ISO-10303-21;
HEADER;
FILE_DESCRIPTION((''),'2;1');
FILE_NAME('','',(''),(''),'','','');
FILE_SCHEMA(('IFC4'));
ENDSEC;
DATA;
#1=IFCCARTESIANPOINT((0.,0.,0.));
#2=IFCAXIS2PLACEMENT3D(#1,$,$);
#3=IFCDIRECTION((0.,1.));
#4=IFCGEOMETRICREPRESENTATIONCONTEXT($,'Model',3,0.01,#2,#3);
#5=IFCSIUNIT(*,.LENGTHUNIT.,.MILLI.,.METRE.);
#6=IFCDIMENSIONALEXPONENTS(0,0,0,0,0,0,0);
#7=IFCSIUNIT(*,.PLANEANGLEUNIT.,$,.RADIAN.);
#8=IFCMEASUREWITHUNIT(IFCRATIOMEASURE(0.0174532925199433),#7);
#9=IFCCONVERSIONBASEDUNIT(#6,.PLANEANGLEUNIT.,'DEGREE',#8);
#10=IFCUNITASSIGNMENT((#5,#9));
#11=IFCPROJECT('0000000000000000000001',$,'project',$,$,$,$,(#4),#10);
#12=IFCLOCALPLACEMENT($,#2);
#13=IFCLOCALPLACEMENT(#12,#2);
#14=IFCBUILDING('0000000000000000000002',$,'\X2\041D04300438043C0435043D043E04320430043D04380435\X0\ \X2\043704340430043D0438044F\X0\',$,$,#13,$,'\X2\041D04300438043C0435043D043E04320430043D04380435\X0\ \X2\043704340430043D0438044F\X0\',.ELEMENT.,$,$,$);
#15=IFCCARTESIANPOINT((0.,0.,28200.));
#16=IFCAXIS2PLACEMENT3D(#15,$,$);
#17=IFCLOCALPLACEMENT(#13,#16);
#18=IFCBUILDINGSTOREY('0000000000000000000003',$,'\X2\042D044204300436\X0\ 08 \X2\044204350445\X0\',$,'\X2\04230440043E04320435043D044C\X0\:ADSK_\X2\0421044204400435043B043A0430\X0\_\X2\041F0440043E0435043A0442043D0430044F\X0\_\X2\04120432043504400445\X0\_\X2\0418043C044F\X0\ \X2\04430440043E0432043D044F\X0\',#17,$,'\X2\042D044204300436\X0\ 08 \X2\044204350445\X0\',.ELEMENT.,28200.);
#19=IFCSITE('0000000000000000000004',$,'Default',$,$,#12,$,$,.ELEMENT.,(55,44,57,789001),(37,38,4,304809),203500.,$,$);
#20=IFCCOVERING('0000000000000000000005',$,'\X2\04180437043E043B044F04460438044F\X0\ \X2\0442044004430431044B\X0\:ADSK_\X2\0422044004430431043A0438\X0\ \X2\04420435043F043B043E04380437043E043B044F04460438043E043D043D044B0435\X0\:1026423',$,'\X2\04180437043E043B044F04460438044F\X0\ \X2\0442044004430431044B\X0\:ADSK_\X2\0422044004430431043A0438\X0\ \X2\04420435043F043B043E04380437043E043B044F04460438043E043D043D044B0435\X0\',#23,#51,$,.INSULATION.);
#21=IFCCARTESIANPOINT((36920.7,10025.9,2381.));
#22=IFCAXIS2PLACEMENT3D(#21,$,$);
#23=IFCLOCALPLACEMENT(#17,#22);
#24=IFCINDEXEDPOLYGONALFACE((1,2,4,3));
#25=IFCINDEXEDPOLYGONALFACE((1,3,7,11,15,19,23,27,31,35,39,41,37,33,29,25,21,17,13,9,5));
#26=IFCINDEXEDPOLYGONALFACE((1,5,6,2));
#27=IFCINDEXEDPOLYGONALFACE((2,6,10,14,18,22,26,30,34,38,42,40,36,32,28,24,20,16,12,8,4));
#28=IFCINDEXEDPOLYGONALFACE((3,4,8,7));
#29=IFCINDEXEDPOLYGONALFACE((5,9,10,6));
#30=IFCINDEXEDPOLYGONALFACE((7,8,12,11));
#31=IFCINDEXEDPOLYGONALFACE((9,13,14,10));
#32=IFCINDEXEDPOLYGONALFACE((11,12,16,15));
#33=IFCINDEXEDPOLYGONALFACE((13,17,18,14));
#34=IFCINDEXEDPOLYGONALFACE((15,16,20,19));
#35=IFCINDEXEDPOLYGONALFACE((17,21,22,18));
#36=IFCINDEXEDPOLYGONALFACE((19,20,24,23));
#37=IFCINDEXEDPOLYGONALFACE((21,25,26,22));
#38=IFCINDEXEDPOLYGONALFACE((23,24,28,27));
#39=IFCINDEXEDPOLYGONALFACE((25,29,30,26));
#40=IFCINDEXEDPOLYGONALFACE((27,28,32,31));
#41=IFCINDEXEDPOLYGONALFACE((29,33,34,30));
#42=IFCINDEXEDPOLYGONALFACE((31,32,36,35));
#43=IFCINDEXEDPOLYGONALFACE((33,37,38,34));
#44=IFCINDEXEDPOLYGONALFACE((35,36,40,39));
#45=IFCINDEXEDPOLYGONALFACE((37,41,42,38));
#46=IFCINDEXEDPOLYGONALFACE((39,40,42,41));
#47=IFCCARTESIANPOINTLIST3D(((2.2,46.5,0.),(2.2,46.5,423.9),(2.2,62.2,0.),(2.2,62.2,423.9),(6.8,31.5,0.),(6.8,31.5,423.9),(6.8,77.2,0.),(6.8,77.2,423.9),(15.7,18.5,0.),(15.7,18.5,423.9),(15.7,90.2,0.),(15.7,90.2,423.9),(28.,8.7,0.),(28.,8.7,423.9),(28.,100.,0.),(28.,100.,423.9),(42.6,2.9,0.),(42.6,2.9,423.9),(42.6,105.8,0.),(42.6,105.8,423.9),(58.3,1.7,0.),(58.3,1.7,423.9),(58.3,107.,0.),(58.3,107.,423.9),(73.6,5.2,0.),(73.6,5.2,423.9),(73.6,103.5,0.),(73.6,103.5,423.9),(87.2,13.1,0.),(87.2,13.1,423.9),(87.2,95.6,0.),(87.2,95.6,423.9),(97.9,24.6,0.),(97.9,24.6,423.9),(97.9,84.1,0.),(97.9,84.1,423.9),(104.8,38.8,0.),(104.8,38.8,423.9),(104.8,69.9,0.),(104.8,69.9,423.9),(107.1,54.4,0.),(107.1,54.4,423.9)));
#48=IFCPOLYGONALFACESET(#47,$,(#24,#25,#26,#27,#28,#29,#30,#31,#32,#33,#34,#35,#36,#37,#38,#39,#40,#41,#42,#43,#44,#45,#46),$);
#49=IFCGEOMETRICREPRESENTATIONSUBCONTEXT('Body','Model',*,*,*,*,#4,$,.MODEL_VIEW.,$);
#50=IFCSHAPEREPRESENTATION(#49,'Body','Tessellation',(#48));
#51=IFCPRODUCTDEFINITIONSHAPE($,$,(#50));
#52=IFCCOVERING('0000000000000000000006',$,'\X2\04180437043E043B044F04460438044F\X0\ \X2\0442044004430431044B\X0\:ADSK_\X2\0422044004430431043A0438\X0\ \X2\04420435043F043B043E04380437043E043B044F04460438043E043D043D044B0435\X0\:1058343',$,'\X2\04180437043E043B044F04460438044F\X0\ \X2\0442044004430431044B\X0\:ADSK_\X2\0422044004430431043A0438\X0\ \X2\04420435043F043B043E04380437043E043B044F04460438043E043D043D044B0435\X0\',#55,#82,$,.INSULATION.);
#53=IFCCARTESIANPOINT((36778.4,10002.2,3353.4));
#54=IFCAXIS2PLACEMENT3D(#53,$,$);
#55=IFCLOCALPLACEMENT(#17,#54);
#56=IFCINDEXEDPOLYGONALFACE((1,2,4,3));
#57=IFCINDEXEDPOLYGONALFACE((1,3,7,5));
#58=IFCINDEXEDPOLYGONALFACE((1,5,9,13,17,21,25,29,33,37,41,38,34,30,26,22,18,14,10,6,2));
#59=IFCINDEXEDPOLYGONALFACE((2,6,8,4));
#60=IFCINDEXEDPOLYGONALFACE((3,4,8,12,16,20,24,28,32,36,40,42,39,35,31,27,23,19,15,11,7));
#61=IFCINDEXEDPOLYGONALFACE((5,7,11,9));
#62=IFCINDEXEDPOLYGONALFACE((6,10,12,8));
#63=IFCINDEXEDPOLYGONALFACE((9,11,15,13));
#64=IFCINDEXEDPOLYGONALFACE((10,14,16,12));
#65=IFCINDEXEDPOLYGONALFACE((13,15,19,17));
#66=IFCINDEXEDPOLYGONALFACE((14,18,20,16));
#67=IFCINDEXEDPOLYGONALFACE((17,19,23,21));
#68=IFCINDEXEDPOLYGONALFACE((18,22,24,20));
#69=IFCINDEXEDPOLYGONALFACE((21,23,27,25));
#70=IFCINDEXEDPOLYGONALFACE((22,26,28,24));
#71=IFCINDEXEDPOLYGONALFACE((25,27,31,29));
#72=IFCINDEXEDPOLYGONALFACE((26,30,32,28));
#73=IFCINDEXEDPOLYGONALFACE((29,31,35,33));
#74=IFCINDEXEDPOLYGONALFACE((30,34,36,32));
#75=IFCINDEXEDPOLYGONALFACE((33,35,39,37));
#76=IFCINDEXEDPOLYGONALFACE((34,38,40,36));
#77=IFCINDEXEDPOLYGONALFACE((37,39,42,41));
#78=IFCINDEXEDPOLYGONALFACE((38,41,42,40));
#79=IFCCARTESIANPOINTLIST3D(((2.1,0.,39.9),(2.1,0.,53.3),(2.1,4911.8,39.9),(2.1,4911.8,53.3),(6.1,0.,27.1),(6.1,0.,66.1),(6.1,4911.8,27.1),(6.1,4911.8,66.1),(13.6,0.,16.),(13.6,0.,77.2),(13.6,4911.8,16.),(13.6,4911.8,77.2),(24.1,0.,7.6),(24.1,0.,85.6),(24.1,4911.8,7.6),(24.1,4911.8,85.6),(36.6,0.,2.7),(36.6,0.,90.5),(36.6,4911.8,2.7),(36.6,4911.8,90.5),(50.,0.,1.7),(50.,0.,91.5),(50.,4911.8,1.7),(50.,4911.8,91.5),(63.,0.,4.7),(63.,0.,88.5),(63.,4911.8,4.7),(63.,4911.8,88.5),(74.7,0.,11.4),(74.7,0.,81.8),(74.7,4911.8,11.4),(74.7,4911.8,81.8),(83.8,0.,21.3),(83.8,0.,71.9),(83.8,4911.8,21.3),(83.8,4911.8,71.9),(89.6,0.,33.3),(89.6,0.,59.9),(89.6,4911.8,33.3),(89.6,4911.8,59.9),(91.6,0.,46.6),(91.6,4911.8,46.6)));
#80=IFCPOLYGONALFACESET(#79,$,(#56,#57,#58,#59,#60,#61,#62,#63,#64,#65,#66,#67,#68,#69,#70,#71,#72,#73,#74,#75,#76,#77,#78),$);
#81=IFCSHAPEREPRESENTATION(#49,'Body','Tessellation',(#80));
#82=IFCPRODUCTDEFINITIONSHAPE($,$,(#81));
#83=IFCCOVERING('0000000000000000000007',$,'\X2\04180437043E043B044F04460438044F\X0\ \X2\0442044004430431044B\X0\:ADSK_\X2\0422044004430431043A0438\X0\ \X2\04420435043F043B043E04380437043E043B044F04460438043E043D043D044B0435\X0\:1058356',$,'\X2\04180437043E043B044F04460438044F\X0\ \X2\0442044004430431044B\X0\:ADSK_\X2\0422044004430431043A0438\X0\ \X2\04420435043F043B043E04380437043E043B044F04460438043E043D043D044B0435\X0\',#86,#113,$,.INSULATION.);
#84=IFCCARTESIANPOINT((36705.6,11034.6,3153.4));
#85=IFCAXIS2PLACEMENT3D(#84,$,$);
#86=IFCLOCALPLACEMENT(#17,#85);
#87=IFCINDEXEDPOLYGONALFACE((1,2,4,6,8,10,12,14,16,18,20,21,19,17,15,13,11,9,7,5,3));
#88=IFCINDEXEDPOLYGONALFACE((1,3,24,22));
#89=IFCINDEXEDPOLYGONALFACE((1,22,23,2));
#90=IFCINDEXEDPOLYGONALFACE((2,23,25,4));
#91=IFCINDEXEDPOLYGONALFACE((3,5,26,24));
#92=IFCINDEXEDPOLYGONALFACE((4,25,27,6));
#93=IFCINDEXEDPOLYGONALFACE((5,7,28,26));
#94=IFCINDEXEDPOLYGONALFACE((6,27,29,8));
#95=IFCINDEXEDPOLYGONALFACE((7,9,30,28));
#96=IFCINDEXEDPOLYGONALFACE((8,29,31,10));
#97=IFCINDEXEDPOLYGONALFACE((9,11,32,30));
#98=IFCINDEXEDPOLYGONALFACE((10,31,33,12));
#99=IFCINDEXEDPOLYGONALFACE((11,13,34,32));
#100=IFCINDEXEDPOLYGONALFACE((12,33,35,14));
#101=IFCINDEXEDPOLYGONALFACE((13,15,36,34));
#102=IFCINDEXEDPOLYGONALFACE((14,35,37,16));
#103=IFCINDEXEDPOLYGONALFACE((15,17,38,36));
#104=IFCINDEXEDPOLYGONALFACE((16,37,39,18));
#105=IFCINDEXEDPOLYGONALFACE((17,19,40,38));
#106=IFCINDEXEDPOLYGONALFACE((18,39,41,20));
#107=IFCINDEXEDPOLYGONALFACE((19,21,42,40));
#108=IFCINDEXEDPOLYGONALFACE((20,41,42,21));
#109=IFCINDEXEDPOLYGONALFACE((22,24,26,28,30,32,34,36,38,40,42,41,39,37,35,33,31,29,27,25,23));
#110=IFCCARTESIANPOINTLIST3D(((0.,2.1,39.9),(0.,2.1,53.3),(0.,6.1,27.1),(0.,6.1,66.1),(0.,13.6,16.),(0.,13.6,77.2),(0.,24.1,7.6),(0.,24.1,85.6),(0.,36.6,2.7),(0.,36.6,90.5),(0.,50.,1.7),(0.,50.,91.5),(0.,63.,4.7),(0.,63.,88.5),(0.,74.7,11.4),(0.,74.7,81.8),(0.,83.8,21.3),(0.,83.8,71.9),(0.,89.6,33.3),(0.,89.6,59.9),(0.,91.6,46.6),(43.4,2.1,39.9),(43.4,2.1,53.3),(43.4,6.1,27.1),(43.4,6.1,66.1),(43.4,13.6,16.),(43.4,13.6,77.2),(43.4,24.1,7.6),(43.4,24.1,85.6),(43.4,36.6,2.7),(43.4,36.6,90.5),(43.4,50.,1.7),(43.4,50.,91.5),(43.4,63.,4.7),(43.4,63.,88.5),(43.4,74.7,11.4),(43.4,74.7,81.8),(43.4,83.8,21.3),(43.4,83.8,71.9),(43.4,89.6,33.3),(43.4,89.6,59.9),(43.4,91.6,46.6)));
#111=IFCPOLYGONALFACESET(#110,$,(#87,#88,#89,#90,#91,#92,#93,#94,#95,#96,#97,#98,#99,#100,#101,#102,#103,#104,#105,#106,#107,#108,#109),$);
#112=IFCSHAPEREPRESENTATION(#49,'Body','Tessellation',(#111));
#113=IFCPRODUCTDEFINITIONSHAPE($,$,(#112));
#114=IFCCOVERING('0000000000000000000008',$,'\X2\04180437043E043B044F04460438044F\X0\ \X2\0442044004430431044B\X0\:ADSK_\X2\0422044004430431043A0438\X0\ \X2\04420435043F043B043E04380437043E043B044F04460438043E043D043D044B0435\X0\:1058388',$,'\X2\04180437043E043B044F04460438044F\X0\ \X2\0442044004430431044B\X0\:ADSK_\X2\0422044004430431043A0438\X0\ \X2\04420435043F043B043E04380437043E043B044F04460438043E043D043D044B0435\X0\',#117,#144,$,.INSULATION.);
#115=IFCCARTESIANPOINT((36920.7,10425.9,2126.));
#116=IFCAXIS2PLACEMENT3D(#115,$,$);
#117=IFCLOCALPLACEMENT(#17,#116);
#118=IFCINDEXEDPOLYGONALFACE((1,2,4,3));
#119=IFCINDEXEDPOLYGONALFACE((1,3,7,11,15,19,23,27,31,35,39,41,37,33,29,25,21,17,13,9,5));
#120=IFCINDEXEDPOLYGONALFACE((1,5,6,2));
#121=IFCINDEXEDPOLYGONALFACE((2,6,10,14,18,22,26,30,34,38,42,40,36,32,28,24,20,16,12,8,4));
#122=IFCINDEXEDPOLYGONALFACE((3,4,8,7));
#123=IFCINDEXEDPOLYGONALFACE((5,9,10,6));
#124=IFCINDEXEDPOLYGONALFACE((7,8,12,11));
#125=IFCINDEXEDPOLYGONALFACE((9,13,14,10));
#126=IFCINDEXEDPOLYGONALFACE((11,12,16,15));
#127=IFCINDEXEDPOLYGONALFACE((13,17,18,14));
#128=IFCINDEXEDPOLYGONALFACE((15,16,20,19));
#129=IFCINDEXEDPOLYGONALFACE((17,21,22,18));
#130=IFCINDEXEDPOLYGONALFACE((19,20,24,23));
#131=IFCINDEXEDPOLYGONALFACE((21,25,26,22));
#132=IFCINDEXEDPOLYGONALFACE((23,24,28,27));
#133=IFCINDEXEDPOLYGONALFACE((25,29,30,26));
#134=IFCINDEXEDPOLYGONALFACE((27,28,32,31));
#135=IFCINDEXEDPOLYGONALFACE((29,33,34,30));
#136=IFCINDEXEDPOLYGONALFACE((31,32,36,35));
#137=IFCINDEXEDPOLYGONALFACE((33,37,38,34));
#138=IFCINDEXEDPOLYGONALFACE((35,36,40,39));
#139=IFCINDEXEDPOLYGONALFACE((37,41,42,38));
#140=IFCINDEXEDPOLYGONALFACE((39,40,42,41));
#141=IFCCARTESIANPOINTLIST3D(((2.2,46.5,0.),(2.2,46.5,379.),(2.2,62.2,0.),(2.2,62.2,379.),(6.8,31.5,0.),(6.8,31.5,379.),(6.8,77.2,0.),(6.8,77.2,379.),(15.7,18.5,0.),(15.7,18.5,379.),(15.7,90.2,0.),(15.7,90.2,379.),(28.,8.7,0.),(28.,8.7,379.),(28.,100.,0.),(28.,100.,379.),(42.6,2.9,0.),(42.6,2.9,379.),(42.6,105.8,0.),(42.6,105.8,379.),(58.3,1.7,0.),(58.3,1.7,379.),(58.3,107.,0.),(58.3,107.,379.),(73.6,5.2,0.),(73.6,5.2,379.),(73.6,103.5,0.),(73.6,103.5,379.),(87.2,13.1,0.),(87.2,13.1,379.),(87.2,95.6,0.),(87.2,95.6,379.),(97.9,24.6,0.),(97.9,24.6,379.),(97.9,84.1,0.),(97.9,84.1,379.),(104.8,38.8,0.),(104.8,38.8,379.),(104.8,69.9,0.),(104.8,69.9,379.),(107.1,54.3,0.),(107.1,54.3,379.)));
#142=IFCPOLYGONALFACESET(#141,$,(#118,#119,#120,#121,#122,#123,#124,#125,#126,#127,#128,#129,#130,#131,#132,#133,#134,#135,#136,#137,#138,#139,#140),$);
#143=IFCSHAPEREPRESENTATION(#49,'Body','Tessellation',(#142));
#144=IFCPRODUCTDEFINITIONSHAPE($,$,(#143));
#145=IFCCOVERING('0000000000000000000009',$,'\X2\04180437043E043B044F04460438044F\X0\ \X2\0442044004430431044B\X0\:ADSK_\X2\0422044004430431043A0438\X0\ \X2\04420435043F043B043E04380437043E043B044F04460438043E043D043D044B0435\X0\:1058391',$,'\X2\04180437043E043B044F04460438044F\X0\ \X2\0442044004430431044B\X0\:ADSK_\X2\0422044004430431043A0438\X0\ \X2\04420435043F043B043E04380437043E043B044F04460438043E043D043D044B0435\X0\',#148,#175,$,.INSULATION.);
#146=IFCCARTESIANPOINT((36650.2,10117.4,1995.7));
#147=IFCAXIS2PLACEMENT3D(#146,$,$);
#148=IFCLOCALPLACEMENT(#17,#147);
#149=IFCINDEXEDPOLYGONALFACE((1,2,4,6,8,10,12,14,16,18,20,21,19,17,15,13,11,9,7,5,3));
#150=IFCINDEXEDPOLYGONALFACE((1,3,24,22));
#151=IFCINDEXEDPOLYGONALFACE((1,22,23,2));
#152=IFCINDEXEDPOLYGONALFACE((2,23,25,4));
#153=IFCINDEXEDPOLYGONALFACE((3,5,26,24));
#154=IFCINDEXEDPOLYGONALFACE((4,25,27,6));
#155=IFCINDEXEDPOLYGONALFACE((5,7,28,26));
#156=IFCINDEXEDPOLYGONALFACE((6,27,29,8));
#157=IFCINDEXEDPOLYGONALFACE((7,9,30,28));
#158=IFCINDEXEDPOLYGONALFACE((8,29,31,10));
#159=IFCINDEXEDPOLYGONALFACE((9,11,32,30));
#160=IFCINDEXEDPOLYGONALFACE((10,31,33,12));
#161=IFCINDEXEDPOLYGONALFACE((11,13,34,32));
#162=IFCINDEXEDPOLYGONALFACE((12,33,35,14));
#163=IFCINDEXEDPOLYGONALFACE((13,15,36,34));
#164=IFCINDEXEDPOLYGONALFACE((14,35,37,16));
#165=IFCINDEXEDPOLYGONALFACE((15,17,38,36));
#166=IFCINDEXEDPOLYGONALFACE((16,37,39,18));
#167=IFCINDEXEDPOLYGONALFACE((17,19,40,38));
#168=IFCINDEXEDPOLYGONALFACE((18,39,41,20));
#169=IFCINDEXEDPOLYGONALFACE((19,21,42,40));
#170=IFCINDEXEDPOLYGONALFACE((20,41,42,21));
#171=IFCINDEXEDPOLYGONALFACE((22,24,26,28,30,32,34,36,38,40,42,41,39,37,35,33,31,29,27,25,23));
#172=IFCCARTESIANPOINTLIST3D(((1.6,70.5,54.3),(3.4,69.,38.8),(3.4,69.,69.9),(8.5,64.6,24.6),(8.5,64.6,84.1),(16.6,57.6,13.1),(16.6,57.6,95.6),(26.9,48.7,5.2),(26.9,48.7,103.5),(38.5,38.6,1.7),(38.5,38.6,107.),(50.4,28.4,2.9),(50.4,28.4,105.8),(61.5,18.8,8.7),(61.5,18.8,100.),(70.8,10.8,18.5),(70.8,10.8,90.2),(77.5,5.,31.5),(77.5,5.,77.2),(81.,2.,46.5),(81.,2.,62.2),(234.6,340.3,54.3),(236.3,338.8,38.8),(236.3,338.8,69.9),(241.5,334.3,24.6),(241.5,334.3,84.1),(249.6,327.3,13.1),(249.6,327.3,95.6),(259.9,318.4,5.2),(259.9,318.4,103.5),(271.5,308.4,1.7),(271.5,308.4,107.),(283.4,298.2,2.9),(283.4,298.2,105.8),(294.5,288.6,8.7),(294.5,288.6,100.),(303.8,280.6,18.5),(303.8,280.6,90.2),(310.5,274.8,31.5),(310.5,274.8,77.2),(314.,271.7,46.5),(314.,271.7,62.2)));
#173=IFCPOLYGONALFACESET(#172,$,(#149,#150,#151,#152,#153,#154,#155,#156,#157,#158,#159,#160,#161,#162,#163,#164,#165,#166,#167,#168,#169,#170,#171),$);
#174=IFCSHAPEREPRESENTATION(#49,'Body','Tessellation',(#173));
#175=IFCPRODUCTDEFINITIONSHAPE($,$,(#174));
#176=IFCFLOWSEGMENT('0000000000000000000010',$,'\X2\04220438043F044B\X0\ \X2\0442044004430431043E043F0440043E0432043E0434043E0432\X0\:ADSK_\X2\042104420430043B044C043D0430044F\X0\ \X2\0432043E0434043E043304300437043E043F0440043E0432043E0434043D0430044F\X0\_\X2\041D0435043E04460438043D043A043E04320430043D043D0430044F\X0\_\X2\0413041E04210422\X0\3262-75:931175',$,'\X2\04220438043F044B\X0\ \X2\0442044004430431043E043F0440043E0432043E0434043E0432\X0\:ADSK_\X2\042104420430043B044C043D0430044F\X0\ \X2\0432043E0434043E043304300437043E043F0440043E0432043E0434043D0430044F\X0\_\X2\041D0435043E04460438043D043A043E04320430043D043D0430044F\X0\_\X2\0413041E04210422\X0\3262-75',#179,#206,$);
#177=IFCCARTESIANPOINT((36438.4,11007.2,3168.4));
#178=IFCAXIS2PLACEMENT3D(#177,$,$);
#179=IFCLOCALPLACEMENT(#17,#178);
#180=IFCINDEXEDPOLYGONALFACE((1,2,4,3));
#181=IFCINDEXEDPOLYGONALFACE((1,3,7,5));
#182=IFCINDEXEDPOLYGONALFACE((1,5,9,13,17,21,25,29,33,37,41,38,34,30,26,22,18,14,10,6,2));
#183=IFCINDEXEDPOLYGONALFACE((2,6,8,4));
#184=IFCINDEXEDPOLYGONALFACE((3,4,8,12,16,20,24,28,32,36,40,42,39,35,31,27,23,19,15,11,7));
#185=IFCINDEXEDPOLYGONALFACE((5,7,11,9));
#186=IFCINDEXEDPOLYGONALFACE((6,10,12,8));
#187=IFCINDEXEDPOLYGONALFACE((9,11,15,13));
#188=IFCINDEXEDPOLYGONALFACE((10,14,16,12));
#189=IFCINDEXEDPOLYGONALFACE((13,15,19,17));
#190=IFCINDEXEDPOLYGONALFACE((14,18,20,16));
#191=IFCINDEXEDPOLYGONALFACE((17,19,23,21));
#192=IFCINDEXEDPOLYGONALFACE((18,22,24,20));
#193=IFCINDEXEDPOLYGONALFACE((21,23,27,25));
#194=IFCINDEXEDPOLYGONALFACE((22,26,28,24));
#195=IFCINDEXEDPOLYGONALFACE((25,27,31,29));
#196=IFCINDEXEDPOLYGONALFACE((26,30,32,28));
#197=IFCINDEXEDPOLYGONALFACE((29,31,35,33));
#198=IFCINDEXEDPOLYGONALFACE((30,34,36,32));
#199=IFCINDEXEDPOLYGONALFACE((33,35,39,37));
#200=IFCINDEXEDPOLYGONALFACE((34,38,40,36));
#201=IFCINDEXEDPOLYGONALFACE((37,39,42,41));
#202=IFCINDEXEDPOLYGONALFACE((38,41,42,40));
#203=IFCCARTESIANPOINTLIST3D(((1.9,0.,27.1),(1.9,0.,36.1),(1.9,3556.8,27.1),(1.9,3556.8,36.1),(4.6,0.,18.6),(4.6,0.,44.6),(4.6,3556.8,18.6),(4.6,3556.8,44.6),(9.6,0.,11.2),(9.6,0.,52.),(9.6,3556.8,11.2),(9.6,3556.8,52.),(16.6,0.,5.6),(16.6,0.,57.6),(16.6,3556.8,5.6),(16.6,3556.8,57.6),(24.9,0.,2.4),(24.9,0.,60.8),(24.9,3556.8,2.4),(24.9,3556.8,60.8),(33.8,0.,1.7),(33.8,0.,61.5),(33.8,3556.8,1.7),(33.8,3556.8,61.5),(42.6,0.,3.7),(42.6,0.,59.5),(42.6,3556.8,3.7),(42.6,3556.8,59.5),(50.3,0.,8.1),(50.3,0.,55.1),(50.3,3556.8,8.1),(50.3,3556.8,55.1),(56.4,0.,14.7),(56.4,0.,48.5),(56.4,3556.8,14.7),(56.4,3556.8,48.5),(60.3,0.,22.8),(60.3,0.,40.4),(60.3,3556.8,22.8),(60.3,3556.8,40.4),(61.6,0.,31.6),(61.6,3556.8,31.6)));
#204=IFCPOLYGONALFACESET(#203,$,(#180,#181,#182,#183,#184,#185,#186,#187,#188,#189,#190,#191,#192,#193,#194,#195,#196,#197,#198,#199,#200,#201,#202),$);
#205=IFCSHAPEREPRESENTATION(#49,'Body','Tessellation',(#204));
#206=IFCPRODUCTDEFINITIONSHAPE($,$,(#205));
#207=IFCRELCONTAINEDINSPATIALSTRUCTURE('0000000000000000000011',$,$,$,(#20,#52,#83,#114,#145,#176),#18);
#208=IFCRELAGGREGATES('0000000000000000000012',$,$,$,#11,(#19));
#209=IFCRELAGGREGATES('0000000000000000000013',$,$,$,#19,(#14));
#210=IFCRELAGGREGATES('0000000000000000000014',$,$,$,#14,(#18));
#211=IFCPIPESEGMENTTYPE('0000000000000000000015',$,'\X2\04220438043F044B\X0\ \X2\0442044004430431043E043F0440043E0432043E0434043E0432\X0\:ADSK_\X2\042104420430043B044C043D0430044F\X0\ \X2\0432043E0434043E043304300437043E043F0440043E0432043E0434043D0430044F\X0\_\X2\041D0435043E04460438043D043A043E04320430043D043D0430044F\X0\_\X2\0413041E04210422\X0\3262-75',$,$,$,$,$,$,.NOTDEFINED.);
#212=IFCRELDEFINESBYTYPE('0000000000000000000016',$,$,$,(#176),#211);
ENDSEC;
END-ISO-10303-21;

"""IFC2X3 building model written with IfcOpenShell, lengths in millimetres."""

from ifc_helpers import new_model, entity, si_unit, converted_unit, direction, frame, origin, origin_2d_with_axis, place, context, subcontext, project, spatial, circle, extrude, type_object, element, save


model = new_model("IFC2X3")

# Units and contexts
model_context = context("Model", 3, precision=0.01, world=origin(), true_north=direction((0.0, 1.0)))
body_context = subcontext(model_context, "Body", "Model", "MODEL_VIEW")
ifc_project = project(units=[si_unit("LENGTHUNIT", "METRE", prefix="MILLI"), converted_unit("PLANEANGLEUNIT", "DEGREE", entity("IfcRatioMeasure", 0.0174532925199433), si_unit("PLANEANGLEUNIT", "RADIAN"), dimensions=[0, 0, 0, 0, 0, 0, 0])], contexts=[model_context])

# Site, building, storey
site_placement = place(None, origin())
site = spatial("IfcSite", under=ifc_project, at=site_placement, Name="Default", CompositionType="ELEMENT", RefLatitude=(55, 44, 57, 789001), RefLongitude=(37, 38, 4, 304809), RefElevation=203500.0)
building_placement = place(site_placement, origin())
building = spatial("IfcBuilding", under=site, at=building_placement, Name="Наименование здания", LongName="Наименование здания", CompositionType="ELEMENT")
storey_placement = place(building_placement, frame((0.0, 0.0, 28200.0)))
storey = spatial("IfcBuildingStorey", under=building, at=storey_placement, Name="Этаж 08 тех", ObjectType="Уровень:ADSK_Стрелка_Проектная_Вверх_Имя уровня", LongName="Этаж 08 тех", CompositionType="ELEMENT", Elevation=28200.0)

# Coverings
covering_1_placement = place(storey_placement, frame((36920.7, 10025.9, 2381.0)))
element("IfcCovering", 1, at=covering_1_placement, inside=storey, Name="Изоляция трубы:ADSK_Трубки теплоизоляционные:1026423", ObjectType="Изоляция трубы:ADSK_Трубки теплоизоляционные", PredefinedType="INSULATION", context=body_context, shape_type="SweptSolid", body=[
    extrude(circle(Radius=52.8, at=origin_2d_with_axis()), frame((54.4, 54.4, 0.0)), (0.0, 0.0, 1.0), 423.9),
])
covering_2_placement = place(storey_placement, frame((36778.4, 10002.2, 3353.4)))
element("IfcCovering", 2, at=covering_2_placement, inside=storey, Name="Изоляция трубы:ADSK_Трубки теплоизоляционные:1058343", ObjectType="Изоляция трубы:ADSK_Трубки теплоизоляционные", PredefinedType="INSULATION", context=body_context, shape_type="SweptSolid", body=[
    extrude(circle(Radius=45.0, at=origin_2d_with_axis()), frame((46.6, 0.0, 46.6), z_axis=(0.0, 1.0, 0.0), x_axis=(1.0, 0.0, 0.0)), (0.0, 0.0, 1.0), 4911.8),
])
covering_3_placement = place(storey_placement, frame((36705.6, 11034.6, 3153.4)))
element("IfcCovering", 3, at=covering_3_placement, inside=storey, Name="Изоляция трубы:ADSK_Трубки теплоизоляционные:1058356", ObjectType="Изоляция трубы:ADSK_Трубки теплоизоляционные", PredefinedType="INSULATION", context=body_context, shape_type="SweptSolid", body=[
    extrude(circle(Radius=45.0, at=origin_2d_with_axis()), frame((0.0, 46.6, 46.6), z_axis=(1.0, 0.0, 0.0), x_axis=(0.0, 1.0, 0.0)), (0.0, 0.0, 1.0), 43.4),
])
covering_4_placement = place(storey_placement, frame((36920.7, 10425.9, 2126.0)))
element("IfcCovering", 4, at=covering_4_placement, inside=storey, Name="Изоляция трубы:ADSK_Трубки теплоизоляционные:1058388", ObjectType="Изоляция трубы:ADSK_Трубки теплоизоляционные", PredefinedType="INSULATION", context=body_context, shape_type="SweptSolid", body=[
    extrude(circle(Radius=52.8, at=origin_2d_with_axis()), frame((54.4, 54.4, 0.0)), (0.0, 0.0, 1.0), 379.0),
])
covering_5_placement = place(storey_placement, frame((36650.2, 10117.4, 1995.7)))
element("IfcCovering", 5, at=covering_5_placement, inside=storey, Name="Изоляция трубы:ADSK_Трубки теплоизоляционные:1058391", ObjectType="Изоляция трубы:ADSK_Трубки теплоизоляционные", PredefinedType="INSULATION", context=body_context, shape_type="SweptSolid", body=[
    extrude(circle(Radius=52.8, at=origin_2d_with_axis()), frame((41.5, 36.1, 54.4), z_axis=(0.653617, 0.756825, 0.0), x_axis=(-0.756825, 0.653617, 0.0)), (0.0, 0.0, 1.0), 356.4),
])

# Flow segment
pipe_segment_type = type_object("IfcPipeSegmentType", Name="Типы трубопроводов:ADSK_Стальная водогазопроводная_Неоцинкованная_ГОСТ3262-75", PredefinedType="NOTDEFINED")
flow_segment_1_placement = place(storey_placement, frame((36438.4, 11007.2, 3168.4)))
element("IfcFlowSegment", 6, at=flow_segment_1_placement, inside=storey, type_object=pipe_segment_type, Name="Типы трубопроводов:ADSK_Стальная водогазопроводная_Неоцинкованная_ГОСТ3262-75:931175", ObjectType="Типы трубопроводов:ADSK_Стальная водогазопроводная_Неоцинкованная_ГОСТ3262-75", context=body_context, shape_type="SweptSolid", body=[
    extrude(circle(Radius=30.0, at=origin_2d_with_axis()), frame((31.6, 0.0, 31.6), z_axis=(0.0, 1.0, 0.0), x_axis=(1.0, 0.0, 0.0)), (0.0, 0.0, 1.0), 3556.8),
])

save(model, "model.ifc")
